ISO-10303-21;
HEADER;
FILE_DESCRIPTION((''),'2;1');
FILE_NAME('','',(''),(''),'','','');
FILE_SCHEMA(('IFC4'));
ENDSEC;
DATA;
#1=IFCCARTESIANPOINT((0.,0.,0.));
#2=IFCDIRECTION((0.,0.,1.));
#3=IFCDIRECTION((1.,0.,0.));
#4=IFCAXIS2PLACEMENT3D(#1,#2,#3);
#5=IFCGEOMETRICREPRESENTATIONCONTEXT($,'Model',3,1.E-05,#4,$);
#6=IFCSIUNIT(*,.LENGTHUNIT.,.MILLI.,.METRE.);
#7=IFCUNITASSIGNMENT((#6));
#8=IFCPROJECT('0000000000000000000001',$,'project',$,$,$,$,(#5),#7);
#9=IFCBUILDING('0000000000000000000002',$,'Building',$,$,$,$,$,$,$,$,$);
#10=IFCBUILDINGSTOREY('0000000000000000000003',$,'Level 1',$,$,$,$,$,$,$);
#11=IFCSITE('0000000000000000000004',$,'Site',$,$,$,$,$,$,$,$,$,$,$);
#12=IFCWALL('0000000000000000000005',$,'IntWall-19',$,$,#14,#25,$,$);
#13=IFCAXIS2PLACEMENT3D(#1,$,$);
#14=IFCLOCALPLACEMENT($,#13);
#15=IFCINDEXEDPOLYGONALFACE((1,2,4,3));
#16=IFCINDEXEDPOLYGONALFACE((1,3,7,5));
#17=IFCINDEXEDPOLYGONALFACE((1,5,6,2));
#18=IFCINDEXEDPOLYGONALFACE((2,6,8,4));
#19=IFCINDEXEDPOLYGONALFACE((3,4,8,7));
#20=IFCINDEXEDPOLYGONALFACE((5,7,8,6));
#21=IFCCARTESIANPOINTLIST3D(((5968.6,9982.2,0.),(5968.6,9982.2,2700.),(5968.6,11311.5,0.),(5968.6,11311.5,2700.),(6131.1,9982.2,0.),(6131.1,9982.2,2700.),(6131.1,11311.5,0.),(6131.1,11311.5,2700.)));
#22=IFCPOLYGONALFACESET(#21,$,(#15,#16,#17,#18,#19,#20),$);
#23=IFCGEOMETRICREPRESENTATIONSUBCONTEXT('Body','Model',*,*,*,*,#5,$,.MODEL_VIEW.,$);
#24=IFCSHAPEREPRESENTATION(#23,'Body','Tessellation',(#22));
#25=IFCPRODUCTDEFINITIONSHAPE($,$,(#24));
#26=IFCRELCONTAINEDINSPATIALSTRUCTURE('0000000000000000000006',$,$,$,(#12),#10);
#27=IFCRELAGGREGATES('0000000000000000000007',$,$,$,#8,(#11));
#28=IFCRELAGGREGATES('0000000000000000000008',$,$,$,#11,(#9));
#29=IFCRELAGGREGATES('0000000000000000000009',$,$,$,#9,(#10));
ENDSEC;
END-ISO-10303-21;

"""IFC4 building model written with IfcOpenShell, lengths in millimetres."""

from ifc_helpers import new_model, si_unit, frame, origin_with_axes, place, context, subcontext, project, spatial, indexed_curve, outline, extrude, element, save


model = new_model("IFC4")

# Units and contexts
model_context = context("Model", 3, precision=1e-05, world=origin_with_axes())
body_context = subcontext(model_context, "Body", "Model", "MODEL_VIEW")
ifc_project = project(units=[si_unit("LENGTHUNIT", "METRE", prefix="MILLI")], contexts=[model_context])

# Site, building, storey
site = spatial("IfcSite", under=ifc_project, Name="Site")
building = spatial("IfcBuilding", under=site, Name="Building")
storey = spatial("IfcBuildingStorey", under=building, Name="Level 1")

# Wall
wall_1_placement = place(None, frame((6049.9, 9982.2, 0.0), z_axis=(0.0, 0.0, 1.0), x_axis=(0.0, 1.0, 0.0)))
element("IfcWall", 1, at=wall_1_placement, inside=storey, Name="IntWall-19", context=body_context, shape_type="SweptSolid", body=[
    extrude(outline(indexed_curve([(0.0, 0.0), (0.0, 162.5), (1329.3, 162.5), (1329.3, 0.0), (0.0, 0.0)], self_intersect=False)), frame((0.0, -81.3, 0.0), z_axis=(0.0, 0.0, 1.0), x_axis=(1.0, 0.0, 0.0)), (0.0, 0.0, 1.0), 2700.0),
])

save(model, "model.ifc")
